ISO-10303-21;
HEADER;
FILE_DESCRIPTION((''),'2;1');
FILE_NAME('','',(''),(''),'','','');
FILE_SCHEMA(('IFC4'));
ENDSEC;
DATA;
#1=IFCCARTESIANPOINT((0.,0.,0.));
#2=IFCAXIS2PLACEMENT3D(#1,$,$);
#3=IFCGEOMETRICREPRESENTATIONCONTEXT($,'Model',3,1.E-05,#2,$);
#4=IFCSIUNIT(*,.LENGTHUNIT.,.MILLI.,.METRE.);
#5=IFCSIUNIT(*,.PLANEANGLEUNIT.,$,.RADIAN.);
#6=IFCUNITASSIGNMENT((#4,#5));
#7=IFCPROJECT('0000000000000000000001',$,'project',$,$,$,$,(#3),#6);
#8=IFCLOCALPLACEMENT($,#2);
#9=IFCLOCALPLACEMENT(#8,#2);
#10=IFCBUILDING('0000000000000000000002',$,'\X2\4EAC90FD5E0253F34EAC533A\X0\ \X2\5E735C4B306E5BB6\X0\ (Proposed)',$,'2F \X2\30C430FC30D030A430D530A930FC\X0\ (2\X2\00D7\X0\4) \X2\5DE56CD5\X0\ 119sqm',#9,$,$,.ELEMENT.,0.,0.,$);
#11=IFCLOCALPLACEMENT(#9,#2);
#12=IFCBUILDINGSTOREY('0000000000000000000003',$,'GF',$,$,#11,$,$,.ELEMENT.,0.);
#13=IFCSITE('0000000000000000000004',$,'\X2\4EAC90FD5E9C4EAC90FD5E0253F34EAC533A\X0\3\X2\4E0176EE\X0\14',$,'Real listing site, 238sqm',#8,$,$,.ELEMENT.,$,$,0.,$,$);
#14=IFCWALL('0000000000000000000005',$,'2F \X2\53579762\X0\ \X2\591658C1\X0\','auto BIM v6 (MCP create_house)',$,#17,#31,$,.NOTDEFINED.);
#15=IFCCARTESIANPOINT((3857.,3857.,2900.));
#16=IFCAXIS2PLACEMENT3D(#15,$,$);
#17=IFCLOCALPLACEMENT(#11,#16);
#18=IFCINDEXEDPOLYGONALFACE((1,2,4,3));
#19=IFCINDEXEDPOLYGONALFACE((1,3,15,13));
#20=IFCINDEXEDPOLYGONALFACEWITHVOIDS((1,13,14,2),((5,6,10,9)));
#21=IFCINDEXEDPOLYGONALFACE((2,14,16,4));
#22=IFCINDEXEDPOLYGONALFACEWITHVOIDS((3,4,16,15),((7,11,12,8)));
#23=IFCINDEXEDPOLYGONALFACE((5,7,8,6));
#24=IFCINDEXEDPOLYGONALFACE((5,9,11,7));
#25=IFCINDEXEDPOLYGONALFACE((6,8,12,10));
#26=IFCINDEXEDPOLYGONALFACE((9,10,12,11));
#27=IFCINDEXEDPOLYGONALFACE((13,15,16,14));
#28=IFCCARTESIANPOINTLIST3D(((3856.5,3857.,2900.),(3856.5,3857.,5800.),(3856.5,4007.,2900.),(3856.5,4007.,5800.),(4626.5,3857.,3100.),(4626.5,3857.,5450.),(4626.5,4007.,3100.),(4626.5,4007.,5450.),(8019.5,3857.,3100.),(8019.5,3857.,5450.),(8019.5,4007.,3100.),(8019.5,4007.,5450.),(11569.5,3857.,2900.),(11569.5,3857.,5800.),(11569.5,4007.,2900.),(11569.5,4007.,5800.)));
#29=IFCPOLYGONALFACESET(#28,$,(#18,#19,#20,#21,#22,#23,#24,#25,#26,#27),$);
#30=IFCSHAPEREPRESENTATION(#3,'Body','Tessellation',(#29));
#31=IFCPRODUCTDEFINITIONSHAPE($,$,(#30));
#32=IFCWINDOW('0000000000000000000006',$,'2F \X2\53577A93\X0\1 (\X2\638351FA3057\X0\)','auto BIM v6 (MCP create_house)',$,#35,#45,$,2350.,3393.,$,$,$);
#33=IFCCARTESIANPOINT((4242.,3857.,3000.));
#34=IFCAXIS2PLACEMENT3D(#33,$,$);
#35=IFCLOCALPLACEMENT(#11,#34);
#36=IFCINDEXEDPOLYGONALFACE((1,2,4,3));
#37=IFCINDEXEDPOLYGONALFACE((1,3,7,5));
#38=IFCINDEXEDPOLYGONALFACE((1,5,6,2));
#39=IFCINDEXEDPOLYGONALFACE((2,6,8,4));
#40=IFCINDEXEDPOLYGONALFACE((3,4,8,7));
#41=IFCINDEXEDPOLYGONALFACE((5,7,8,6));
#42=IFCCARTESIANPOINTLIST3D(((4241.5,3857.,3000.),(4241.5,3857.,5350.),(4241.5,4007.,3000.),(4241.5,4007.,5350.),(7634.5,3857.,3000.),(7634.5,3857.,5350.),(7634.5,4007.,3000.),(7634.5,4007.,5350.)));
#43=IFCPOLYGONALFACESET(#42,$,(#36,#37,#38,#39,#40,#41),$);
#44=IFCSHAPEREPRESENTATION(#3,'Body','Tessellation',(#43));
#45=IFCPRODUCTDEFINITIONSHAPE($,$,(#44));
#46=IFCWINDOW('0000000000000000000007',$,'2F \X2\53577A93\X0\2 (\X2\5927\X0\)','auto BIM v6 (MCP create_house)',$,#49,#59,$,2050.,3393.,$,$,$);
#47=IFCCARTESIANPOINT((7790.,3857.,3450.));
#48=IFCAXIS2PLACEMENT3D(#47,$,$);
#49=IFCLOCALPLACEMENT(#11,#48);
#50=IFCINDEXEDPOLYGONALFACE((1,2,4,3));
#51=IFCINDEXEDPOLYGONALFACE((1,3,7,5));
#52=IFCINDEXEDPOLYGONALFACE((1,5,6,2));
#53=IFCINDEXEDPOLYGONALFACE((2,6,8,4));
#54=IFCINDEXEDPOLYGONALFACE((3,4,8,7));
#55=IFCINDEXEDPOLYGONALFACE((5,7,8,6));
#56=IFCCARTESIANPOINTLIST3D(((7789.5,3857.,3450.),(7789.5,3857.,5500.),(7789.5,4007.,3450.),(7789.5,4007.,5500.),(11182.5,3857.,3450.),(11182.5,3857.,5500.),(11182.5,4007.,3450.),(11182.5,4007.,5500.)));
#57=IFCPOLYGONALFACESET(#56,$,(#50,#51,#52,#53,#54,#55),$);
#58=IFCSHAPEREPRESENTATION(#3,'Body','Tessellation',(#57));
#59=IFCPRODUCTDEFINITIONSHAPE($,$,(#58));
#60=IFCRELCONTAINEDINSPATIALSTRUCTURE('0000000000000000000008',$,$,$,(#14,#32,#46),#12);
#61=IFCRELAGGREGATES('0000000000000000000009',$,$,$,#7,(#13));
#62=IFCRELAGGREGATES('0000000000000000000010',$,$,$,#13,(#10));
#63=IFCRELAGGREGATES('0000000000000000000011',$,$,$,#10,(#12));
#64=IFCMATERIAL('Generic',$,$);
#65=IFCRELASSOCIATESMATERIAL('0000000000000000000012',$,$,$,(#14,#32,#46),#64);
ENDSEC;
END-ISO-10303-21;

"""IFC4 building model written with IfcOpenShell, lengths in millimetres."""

from ifc_helpers import new_model, si_unit, frame, frame_2d, origin, place, context, project, spatial, rectangle, extrude, material, element, fill, save


model = new_model("IFC4")

# Units and contexts
model_context = context("Model", 3, precision=1e-05, world=origin())
ifc_project = project(units=[si_unit("LENGTHUNIT", "METRE", prefix="MILLI"), si_unit("PLANEANGLEUNIT", "RADIAN")], contexts=[model_context])

# Site, building, storey
site_placement = place(None, origin())
site = spatial("IfcSite", under=ifc_project, at=site_placement, Name="京都府京都市右京区3丁目14", ObjectType="Real listing site, 238sqm", CompositionType="ELEMENT", RefElevation=0.0)
building_placement = place(site_placement, origin())
building = spatial("IfcBuilding", under=site, at=building_placement, Name="京都市右京区 平屋の家 (Proposed)", ObjectType="2F ツーバイフォー (2×4) 工法 119sqm", CompositionType="ELEMENT", ElevationOfRefHeight=0.0, ElevationOfTerrain=0.0)
storey_placement = place(building_placement, origin())
storey = spatial("IfcBuildingStorey", under=building, at=storey_placement, Name="GF", CompositionType="ELEMENT", Elevation=0.0)

# Shared definitions
ifc_material = material(Name="Generic")

# Wall, openings, windows
wall_1_placement = place(storey_placement, frame((3857.0, 3857.0, 2900.0)))
wall_1 = element("IfcWall", 1, at=wall_1_placement, inside=storey, material=ifc_material, Name="2F 南面 外壁", Description="auto BIM v6 (MCP create_house)", PredefinedType="NOTDEFINED", context=model_context, shape_type="SweptSolid", body=[
    extrude(rectangle(XDim=7713.0, YDim=150.0, at=frame_2d((3856.0, 75.0))), frame((3857.0, 3857.0, 2900.0)), (0.0, 0.0, 1.0), 2900.0),
])
opening_1_placement = place(storey_placement, frame((4242.0, 3857.0, 3000.0)))
opening_1 = element("IfcOpeningElement", 2, at=opening_1_placement, cuts=wall_1, PredefinedType="NOTDEFINED", context=model_context, shape_type="SweptSolid", body=[
    extrude(rectangle(XDim=3393.0, YDim=150.0, at=frame_2d((1696.0, 75.0))), frame((4242.0, 3857.0, 3000.0)), (0.0, 0.0, 1.0), 2350.0),
])
opening_2_placement = place(storey_placement, frame((7790.0, 3857.0, 3450.0)))
opening_2 = element("IfcOpeningElement", 3, at=opening_2_placement, cuts=wall_1, PredefinedType="NOTDEFINED", context=model_context, shape_type="SweptSolid", body=[
    extrude(rectangle(XDim=3393.0, YDim=150.0, at=frame_2d((1696.0, 75.0))), frame((7790.0, 3857.0, 3450.0)), (0.0, 0.0, 1.0), 2050.0),
])
window_1_placement = place(storey_placement, frame((4242.0, 3857.0, 3000.0)))
window_1 = element("IfcWindow", 4, at=window_1_placement, inside=storey, material=ifc_material, Name="2F 南窓1 (掃出し)", Description="auto BIM v6 (MCP create_house)", OverallHeight=2350.0, OverallWidth=3393.0, context=model_context, shape_type="SweptSolid", body=[
    extrude(rectangle(XDim=3393.0, YDim=150.0, at=frame_2d((1696.0, 75.0))), frame((4242.0, 3857.0, 3000.0)), (0.0, 0.0, 1.0), 2350.0),
])
fill(opening_1, window_1)
window_2_placement = place(storey_placement, frame((7790.0, 3857.0, 3450.0)))
window_2 = element("IfcWindow", 5, at=window_2_placement, inside=storey, material=ifc_material, Name="2F 南窓2 (大)", Description="auto BIM v6 (MCP create_house)", OverallHeight=2050.0, OverallWidth=3393.0, context=model_context, shape_type="SweptSolid", body=[
    extrude(rectangle(XDim=3393.0, YDim=150.0, at=frame_2d((1696.0, 75.0))), frame((7790.0, 3857.0, 3450.0)), (0.0, 0.0, 1.0), 2050.0),
])
fill(opening_2, window_2)

save(model, "model.ifc")
